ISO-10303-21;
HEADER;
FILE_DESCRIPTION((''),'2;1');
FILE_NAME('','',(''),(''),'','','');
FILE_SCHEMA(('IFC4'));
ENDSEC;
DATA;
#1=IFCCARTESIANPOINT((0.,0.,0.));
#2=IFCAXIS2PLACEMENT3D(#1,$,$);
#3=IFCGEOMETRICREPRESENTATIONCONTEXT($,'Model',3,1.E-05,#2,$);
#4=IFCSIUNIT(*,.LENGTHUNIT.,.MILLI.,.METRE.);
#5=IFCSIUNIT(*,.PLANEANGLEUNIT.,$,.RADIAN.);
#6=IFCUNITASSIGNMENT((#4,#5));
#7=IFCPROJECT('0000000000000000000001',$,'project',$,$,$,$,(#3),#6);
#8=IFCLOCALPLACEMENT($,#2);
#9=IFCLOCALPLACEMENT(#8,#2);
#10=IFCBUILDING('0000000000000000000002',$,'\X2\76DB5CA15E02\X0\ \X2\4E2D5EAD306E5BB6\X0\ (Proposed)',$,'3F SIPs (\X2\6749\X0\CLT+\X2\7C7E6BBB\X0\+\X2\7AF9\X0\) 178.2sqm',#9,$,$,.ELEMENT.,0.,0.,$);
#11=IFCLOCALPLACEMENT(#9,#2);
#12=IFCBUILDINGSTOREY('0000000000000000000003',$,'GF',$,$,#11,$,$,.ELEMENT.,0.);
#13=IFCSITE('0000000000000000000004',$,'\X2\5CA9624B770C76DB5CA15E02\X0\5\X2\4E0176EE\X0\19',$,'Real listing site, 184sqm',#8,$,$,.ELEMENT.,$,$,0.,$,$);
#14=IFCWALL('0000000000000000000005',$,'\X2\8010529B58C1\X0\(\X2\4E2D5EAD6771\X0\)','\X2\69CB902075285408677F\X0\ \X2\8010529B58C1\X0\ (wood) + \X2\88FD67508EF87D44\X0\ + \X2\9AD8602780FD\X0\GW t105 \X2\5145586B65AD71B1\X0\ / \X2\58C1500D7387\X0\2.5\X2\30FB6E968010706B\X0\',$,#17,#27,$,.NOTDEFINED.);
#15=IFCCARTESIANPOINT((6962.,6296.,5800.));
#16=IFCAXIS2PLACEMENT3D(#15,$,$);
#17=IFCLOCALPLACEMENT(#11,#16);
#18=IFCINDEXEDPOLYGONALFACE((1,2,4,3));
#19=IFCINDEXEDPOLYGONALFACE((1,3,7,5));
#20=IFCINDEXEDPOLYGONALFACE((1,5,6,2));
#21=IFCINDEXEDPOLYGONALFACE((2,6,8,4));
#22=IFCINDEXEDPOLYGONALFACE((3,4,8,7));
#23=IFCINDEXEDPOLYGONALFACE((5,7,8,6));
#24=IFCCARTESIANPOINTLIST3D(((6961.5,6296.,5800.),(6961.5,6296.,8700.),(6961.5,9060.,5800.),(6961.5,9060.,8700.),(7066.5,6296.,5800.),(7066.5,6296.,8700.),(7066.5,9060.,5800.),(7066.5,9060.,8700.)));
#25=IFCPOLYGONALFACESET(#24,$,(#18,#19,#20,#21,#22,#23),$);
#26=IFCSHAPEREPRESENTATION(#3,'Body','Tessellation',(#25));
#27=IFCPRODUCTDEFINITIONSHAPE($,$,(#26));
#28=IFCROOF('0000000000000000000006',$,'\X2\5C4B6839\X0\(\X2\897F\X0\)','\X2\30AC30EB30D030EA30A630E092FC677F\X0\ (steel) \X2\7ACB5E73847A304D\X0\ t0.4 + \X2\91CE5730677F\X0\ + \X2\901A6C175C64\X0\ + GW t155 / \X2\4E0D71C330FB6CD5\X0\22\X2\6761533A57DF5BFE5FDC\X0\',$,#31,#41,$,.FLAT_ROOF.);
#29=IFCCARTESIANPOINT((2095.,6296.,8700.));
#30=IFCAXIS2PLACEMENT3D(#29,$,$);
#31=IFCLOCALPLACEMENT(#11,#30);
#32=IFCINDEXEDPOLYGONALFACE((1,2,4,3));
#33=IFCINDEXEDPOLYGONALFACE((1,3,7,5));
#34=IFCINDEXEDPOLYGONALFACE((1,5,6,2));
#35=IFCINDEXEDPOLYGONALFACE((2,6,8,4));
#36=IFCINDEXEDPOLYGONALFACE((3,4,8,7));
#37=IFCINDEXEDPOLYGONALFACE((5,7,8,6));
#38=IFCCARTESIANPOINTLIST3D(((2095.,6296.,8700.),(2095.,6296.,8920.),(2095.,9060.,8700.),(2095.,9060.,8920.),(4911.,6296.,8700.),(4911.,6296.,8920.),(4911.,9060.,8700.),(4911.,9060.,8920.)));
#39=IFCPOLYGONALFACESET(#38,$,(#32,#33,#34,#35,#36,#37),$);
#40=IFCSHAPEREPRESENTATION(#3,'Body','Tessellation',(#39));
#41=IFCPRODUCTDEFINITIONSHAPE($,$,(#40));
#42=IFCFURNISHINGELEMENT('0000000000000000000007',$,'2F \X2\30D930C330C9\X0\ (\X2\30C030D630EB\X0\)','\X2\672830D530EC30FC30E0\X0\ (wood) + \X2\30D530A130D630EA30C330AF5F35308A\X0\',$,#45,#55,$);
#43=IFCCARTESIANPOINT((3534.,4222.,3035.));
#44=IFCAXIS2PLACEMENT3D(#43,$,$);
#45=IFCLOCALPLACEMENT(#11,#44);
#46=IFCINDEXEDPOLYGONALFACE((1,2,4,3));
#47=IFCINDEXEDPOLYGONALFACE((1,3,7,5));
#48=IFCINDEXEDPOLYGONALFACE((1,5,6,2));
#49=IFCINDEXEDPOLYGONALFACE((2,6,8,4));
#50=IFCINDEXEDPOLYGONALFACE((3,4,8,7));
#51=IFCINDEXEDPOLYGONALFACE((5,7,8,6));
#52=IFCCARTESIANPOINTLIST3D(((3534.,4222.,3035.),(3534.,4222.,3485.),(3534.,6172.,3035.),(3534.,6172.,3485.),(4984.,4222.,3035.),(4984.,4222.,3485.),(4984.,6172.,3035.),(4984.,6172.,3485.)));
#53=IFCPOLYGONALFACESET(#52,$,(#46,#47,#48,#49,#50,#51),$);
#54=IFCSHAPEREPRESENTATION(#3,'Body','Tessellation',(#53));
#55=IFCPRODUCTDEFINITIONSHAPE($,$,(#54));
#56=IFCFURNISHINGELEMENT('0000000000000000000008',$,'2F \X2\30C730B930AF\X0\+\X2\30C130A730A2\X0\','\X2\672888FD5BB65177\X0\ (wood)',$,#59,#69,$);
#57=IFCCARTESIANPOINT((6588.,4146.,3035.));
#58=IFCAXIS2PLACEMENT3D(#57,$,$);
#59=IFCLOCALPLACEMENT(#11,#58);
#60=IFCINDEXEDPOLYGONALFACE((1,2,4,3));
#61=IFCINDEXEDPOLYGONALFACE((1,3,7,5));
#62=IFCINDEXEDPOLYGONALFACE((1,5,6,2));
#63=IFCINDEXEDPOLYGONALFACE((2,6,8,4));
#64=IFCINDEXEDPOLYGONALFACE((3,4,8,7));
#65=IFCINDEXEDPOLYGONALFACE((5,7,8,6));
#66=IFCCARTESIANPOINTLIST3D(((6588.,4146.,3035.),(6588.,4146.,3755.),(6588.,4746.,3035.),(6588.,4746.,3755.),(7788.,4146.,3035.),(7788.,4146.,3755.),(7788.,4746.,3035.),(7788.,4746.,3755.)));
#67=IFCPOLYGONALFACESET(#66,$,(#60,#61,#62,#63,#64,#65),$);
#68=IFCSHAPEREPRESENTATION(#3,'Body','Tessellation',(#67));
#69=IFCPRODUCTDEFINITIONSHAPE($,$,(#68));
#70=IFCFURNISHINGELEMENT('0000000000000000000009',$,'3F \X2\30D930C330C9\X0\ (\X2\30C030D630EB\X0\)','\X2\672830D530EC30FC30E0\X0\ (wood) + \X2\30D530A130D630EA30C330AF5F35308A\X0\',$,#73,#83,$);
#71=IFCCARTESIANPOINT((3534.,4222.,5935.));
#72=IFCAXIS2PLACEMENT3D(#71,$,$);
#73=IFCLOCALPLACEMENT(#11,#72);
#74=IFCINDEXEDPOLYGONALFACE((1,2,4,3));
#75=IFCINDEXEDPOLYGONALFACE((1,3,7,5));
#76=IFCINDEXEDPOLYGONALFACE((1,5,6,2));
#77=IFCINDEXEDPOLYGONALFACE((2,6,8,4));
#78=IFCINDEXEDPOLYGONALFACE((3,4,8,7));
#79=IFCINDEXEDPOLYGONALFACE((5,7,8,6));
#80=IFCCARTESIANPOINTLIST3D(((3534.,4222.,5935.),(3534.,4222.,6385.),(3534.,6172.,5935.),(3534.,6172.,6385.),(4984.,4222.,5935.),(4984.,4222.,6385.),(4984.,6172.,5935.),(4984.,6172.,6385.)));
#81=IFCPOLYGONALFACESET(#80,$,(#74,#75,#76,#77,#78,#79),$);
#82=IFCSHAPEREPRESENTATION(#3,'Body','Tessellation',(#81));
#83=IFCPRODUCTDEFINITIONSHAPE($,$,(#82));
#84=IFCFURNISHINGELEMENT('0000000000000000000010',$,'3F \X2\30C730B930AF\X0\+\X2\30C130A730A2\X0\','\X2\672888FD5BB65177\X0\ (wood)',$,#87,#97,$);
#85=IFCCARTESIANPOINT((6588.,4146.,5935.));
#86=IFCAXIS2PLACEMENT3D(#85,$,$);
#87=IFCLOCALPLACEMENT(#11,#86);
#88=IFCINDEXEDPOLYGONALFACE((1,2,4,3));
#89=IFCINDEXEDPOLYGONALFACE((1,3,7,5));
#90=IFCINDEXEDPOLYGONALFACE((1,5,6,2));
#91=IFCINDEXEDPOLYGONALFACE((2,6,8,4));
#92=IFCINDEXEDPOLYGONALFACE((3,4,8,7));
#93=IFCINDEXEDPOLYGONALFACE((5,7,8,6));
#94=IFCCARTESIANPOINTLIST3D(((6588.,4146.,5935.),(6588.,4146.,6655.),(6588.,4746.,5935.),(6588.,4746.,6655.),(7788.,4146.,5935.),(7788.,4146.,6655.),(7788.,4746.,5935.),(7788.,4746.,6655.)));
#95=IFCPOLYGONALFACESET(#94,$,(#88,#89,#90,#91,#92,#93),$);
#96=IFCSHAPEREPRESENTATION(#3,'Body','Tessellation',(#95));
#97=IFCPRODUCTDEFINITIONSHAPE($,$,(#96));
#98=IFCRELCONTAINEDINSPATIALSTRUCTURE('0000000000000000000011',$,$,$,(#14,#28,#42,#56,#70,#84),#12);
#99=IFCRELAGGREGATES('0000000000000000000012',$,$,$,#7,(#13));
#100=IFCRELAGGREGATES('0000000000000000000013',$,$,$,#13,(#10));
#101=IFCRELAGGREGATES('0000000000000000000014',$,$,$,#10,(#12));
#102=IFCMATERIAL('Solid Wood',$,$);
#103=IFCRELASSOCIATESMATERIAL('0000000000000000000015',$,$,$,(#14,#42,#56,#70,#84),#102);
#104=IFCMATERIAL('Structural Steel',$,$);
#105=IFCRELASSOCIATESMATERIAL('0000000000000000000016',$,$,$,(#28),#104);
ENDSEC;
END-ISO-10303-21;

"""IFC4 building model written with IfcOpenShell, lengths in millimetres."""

from ifc_helpers import new_model, si_unit, frame, frame_2d, origin, place, context, project, spatial, rectangle, extrude, material, element, save


model = new_model("IFC4")

# Units and contexts
model_context = context("Model", 3, precision=1e-05, world=origin())
ifc_project = project(units=[si_unit("LENGTHUNIT", "METRE", prefix="MILLI"), si_unit("PLANEANGLEUNIT", "RADIAN")], contexts=[model_context])

# Site, building, storey
site_placement = place(None, origin())
site = spatial("IfcSite", under=ifc_project, at=site_placement, Name="岩手県盛岡市5丁目19", ObjectType="Real listing site, 184sqm", CompositionType="ELEMENT", RefElevation=0.0)
building_placement = place(site_placement, origin())
building = spatial("IfcBuilding", under=site, at=building_placement, Name="盛岡市 中庭の家 (Proposed)", ObjectType="3F SIPs (杉CLT+籾殻+竹) 178.2sqm", CompositionType="ELEMENT", ElevationOfRefHeight=0.0, ElevationOfTerrain=0.0)
storey_placement = place(building_placement, origin())
storey = spatial("IfcBuildingStorey", under=building, at=storey_placement, Name="GF", CompositionType="ELEMENT", Elevation=0.0)

# Shared definitions
ifc_material_1 = material(Name="Solid Wood")

# Wall
wall_1_placement = place(storey_placement, frame((6962.0, 6296.0, 5800.0)))
element("IfcWall", 1, at=wall_1_placement, inside=storey, material=ifc_material_1, Name="耐力壁(中庭東)", Description="構造用合板 耐力壁 (wood) + 製材軸組 + 高性能GW t105 充填断熱 / 壁倍率2.5・準耐火", PredefinedType="NOTDEFINED", context=model_context, shape_type="SweptSolid", body=[
    extrude(rectangle(XDim=105.0, YDim=2764.0, at=frame_2d((52.0, 1382.0))), frame((6962.0, 6296.0, 5800.0)), (0.0, 0.0, 1.0), 2900.0),
])

# Roof
ifc_material_2 = material(Name="Structural Steel")
roof_1_placement = place(storey_placement, frame((2095.0, 6296.0, 8700.0)))
element("IfcRoof", 2, at=roof_1_placement, inside=storey, material=ifc_material_2, Name="屋根(西)", Description="ガルバリウム鋼板 (steel) 立平葺き t0.4 + 野地板 + 通気層 + GW t155 / 不燃・法22条区域対応", PredefinedType="FLAT_ROOF", context=model_context, shape_type="SweptSolid", body=[
    extrude(rectangle(XDim=2816.0, YDim=2764.0, at=frame_2d((1408.0, 1382.0))), frame((2095.0, 6296.0, 8700.0)), (0.0, 0.0, 1.0), 220.0),
])

# Furnishing elements
furnishing_1_placement = place(storey_placement, frame((3534.0, 4222.0, 3035.0)))
element("IfcFurnishingElement", 3, at=furnishing_1_placement, inside=storey, material=ifc_material_1, Name="2F ベッド (ダブル)", Description="木フレーム (wood) + ファブリック張り", context=model_context, shape_type="SweptSolid", body=[
    extrude(rectangle(XDim=1450.0, YDim=1950.0, at=frame_2d((725.0, 975.0))), frame((3534.0, 4222.0, 3035.0)), (0.0, 0.0, 1.0), 450.0),
])
furnishing_2_placement = place(storey_placement, frame((6588.0, 4146.0, 3035.0)))
element("IfcFurnishingElement", 4, at=furnishing_2_placement, inside=storey, material=ifc_material_1, Name="2F デスク+チェア", Description="木製家具 (wood)", context=model_context, shape_type="SweptSolid", body=[
    extrude(rectangle(XDim=1200.0, YDim=600.0, at=frame_2d((600.0, 300.0))), frame((6588.0, 4146.0, 3035.0)), (0.0, 0.0, 1.0), 720.0),
])
furnishing_3_placement = place(storey_placement, frame((3534.0, 4222.0, 5935.0)))
element("IfcFurnishingElement", 5, at=furnishing_3_placement, inside=storey, material=ifc_material_1, Name="3F ベッド (ダブル)", Description="木フレーム (wood) + ファブリック張り", context=model_context, shape_type="SweptSolid", body=[
    extrude(rectangle(XDim=1450.0, YDim=1950.0, at=frame_2d((725.0, 975.0))), frame((3534.0, 4222.0, 5935.0)), (0.0, 0.0, 1.0), 450.0),
])
furnishing_4_placement = place(storey_placement, frame((6588.0, 4146.0, 5935.0)))
element("IfcFurnishingElement", 6, at=furnishing_4_placement, inside=storey, material=ifc_material_1, Name="3F デスク+チェア", Description="木製家具 (wood)", context=model_context, shape_type="SweptSolid", body=[
    extrude(rectangle(XDim=1200.0, YDim=600.0, at=frame_2d((600.0, 300.0))), frame((6588.0, 4146.0, 5935.0)), (0.0, 0.0, 1.0), 720.0),
])

save(model, "model.ifc")
